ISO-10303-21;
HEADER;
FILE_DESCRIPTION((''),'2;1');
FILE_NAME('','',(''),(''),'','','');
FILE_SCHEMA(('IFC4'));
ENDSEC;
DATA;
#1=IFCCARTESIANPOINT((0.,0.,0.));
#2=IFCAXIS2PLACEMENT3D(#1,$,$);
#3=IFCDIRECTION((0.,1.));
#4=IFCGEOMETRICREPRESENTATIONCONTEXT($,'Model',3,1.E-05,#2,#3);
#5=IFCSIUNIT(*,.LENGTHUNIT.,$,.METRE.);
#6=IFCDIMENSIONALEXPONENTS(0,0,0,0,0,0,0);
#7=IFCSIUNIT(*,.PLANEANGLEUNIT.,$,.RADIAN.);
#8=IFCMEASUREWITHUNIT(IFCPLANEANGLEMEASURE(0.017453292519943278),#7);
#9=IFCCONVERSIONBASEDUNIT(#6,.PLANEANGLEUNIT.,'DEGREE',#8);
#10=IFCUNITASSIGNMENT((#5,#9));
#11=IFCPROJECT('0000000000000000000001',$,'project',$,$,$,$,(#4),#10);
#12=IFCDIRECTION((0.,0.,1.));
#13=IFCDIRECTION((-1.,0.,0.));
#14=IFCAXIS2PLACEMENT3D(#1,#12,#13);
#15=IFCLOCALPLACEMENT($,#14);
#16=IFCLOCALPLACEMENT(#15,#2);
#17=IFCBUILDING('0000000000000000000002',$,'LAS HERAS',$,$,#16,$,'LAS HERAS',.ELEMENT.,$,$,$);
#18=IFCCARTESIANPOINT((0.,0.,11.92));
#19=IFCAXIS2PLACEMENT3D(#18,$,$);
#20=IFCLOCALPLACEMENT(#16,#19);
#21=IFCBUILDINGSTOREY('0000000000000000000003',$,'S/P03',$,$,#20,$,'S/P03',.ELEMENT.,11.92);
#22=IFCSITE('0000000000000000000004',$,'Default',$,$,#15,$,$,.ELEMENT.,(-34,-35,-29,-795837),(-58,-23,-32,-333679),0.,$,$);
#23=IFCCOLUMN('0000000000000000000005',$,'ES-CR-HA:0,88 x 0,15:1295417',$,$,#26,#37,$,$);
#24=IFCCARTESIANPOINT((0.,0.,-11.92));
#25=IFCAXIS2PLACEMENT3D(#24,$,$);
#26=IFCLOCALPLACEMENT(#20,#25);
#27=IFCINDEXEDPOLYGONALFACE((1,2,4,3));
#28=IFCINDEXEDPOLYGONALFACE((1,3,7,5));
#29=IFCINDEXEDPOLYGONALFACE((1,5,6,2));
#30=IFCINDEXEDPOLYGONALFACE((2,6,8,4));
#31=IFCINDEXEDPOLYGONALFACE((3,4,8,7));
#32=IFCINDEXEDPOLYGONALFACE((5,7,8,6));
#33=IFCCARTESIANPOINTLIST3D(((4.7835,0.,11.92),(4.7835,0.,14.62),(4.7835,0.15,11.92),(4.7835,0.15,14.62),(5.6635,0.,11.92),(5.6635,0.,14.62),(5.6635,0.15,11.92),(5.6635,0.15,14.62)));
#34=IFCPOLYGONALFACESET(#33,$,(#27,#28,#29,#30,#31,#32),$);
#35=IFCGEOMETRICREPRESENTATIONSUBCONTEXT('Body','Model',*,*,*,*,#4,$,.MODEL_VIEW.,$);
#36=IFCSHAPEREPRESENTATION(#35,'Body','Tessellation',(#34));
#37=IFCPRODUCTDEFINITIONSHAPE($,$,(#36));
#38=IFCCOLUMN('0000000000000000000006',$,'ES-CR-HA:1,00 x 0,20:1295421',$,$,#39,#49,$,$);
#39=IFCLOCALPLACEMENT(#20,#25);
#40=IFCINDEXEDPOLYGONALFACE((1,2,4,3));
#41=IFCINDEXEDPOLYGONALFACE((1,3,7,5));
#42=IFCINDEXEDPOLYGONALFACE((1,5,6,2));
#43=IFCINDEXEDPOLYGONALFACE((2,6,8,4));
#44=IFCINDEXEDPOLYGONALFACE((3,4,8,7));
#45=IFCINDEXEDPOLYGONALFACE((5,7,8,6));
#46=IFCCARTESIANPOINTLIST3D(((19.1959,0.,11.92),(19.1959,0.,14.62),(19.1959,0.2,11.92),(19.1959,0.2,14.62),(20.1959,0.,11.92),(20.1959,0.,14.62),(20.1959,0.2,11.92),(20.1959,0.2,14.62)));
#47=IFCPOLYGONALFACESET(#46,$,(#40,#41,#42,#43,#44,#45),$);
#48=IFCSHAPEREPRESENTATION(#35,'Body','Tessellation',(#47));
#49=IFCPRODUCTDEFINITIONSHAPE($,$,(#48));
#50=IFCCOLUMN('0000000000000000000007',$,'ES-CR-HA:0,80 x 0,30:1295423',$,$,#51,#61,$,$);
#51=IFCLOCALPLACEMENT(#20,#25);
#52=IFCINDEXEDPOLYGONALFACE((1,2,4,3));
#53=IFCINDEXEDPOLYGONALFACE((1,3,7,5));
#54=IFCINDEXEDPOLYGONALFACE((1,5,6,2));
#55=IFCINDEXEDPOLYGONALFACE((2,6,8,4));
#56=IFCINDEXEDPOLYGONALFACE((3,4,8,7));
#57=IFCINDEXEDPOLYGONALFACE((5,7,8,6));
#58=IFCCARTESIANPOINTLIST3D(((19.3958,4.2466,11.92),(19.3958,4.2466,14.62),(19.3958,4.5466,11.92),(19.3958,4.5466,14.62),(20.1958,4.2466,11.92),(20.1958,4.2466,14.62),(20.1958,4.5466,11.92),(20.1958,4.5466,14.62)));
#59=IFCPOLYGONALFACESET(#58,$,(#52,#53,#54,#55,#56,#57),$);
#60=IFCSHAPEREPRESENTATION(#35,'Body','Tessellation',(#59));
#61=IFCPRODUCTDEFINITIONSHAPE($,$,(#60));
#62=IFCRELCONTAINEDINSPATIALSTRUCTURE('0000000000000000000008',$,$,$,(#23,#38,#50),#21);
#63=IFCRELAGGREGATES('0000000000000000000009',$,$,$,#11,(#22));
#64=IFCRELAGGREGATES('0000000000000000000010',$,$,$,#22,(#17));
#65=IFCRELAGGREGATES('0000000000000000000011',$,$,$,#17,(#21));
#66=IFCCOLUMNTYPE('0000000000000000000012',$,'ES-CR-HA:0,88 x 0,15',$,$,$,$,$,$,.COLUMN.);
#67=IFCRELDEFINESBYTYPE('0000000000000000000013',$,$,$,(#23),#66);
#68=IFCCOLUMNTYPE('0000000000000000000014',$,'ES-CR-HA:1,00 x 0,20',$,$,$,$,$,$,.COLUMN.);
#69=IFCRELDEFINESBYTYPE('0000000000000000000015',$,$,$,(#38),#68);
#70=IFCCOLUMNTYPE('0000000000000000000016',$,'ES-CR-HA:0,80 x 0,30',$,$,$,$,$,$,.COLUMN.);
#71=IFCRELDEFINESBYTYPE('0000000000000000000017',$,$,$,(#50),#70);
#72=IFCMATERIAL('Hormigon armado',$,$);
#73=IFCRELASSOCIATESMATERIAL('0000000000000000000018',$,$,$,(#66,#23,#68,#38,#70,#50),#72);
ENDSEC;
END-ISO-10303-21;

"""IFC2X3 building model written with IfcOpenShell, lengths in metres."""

from ifc_helpers import new_model, entity, si_unit, converted_unit, direction, frame, frame_2d, origin, place, context, subcontext, project, spatial, rectangle, extrude, source, transform, mapped, material, type_object, type_shapes, element, save


model = new_model("IFC2X3")

# Units and contexts
model_context = context("Model", 3, precision=1e-05, world=origin(), true_north=direction((0.0, 1.0)))
body_context = subcontext(model_context, "Body", "Model", "MODEL_VIEW")
ifc_project = project(units=[si_unit("LENGTHUNIT", "METRE"), converted_unit("PLANEANGLEUNIT", "DEGREE", entity("IfcPlaneAngleMeasure", 0.017453292519943278), si_unit("PLANEANGLEUNIT", "RADIAN"), dimensions=[0, 0, 0, 0, 0, 0, 0])], contexts=[model_context])

# Site, building, storey
site_placement = place(None, frame((0.0, 0.0, 0.0), z_axis=(0.0, 0.0, 1.0), x_axis=(-1.0, 0.0, 0.0)))
site = spatial("IfcSite", under=ifc_project, at=site_placement, Name="Default", CompositionType="ELEMENT", RefLatitude=(-34, -35, -29, -795837), RefLongitude=(-58, -23, -32, -333679), RefElevation=0.0)
building_placement = place(site_placement, origin())
building = spatial("IfcBuilding", under=site, at=building_placement, Name="LAS HERAS", LongName="LAS HERAS", CompositionType="ELEMENT")
storey_placement = place(building_placement, frame((0.0, 0.0, 11.92)))
storey = spatial("IfcBuildingStorey", under=building, at=storey_placement, Name="S/P03", LongName="S/P03", CompositionType="ELEMENT", Elevation=11.92)

# Columns
ifc_material = material(Name="Hormigon armado")
column_type_1 = type_object("IfcColumnType", Name="ES-CR-HA:0,88 x 0,15", PredefinedType="COLUMN", material=ifc_material)
shared_shape_1 = source(origin(), body_context, "Body", "SweptSolid", [
    extrude(rectangle(XDim=2.7, YDim=0.15, at=frame_2d((0.0, 0.0), x_axis=(1.0, 0.0))), frame((4.7835, 0.075, 13.27), z_axis=(1.0, 0.0, 0.0), x_axis=(0.0, 0.0, 1.0)), (0.0, 0.0, 1.0), 0.88),
])
type_shapes(column_type_1, [shared_shape_1])
column_1_placement = place(storey_placement, frame((0.0, 0.0, -11.92)))
element("IfcColumn", 1, at=column_1_placement, inside=storey, type_object=column_type_1, material=ifc_material, Name="ES-CR-HA:0,88 x 0,15:1295417", context=body_context, shape_type="MappedRepresentation", body=[
    mapped(shared_shape_1, transform((0.0, 0.0, 0.0), scale=1.0)),
])
column_type_2 = type_object("IfcColumnType", Name="ES-CR-HA:1,00 x 0,20", PredefinedType="COLUMN", material=ifc_material)
shared_shape_2 = source(origin(), body_context, "Body", "SweptSolid", [
    extrude(rectangle(XDim=2.7, YDim=0.2, at=frame_2d((0.0, 0.0), x_axis=(1.0, 0.0))), frame((19.1959, 0.1, 13.27), z_axis=(1.0, 0.0, 0.0), x_axis=(0.0, 0.0, 1.0)), (0.0, 0.0, 1.0), 1.0),
])
type_shapes(column_type_2, [shared_shape_2])
column_2_placement = place(storey_placement, frame((0.0, 0.0, -11.92)))
element("IfcColumn", 2, at=column_2_placement, inside=storey, type_object=column_type_2, material=ifc_material, Name="ES-CR-HA:1,00 x 0,20:1295421", context=body_context, shape_type="MappedRepresentation", body=[
    mapped(shared_shape_2, transform((0.0, 0.0, 0.0), scale=1.0)),
])
column_type_3 = type_object("IfcColumnType", Name="ES-CR-HA:0,80 x 0,30", PredefinedType="COLUMN", material=ifc_material)
shared_shape_3 = source(origin(), body_context, "Body", "SweptSolid", [
    extrude(rectangle(XDim=2.7, YDim=0.3, at=frame_2d((0.0, 0.0), x_axis=(1.0, 0.0))), frame((19.3958, 4.3966, 13.27), z_axis=(1.0, 0.0, 0.0), x_axis=(0.0, 0.0, 1.0)), (0.0, 0.0, 1.0), 0.8),
])
type_shapes(column_type_3, [shared_shape_3])
column_3_placement = place(storey_placement, frame((0.0, 0.0, -11.92)))
element("IfcColumn", 3, at=column_3_placement, inside=storey, type_object=column_type_3, material=ifc_material, Name="ES-CR-HA:0,80 x 0,30:1295423", context=body_context, shape_type="MappedRepresentation", body=[
    mapped(shared_shape_3, transform((0.0, 0.0, 0.0), scale=1.0)),
])

save(model, "model.ifc")
